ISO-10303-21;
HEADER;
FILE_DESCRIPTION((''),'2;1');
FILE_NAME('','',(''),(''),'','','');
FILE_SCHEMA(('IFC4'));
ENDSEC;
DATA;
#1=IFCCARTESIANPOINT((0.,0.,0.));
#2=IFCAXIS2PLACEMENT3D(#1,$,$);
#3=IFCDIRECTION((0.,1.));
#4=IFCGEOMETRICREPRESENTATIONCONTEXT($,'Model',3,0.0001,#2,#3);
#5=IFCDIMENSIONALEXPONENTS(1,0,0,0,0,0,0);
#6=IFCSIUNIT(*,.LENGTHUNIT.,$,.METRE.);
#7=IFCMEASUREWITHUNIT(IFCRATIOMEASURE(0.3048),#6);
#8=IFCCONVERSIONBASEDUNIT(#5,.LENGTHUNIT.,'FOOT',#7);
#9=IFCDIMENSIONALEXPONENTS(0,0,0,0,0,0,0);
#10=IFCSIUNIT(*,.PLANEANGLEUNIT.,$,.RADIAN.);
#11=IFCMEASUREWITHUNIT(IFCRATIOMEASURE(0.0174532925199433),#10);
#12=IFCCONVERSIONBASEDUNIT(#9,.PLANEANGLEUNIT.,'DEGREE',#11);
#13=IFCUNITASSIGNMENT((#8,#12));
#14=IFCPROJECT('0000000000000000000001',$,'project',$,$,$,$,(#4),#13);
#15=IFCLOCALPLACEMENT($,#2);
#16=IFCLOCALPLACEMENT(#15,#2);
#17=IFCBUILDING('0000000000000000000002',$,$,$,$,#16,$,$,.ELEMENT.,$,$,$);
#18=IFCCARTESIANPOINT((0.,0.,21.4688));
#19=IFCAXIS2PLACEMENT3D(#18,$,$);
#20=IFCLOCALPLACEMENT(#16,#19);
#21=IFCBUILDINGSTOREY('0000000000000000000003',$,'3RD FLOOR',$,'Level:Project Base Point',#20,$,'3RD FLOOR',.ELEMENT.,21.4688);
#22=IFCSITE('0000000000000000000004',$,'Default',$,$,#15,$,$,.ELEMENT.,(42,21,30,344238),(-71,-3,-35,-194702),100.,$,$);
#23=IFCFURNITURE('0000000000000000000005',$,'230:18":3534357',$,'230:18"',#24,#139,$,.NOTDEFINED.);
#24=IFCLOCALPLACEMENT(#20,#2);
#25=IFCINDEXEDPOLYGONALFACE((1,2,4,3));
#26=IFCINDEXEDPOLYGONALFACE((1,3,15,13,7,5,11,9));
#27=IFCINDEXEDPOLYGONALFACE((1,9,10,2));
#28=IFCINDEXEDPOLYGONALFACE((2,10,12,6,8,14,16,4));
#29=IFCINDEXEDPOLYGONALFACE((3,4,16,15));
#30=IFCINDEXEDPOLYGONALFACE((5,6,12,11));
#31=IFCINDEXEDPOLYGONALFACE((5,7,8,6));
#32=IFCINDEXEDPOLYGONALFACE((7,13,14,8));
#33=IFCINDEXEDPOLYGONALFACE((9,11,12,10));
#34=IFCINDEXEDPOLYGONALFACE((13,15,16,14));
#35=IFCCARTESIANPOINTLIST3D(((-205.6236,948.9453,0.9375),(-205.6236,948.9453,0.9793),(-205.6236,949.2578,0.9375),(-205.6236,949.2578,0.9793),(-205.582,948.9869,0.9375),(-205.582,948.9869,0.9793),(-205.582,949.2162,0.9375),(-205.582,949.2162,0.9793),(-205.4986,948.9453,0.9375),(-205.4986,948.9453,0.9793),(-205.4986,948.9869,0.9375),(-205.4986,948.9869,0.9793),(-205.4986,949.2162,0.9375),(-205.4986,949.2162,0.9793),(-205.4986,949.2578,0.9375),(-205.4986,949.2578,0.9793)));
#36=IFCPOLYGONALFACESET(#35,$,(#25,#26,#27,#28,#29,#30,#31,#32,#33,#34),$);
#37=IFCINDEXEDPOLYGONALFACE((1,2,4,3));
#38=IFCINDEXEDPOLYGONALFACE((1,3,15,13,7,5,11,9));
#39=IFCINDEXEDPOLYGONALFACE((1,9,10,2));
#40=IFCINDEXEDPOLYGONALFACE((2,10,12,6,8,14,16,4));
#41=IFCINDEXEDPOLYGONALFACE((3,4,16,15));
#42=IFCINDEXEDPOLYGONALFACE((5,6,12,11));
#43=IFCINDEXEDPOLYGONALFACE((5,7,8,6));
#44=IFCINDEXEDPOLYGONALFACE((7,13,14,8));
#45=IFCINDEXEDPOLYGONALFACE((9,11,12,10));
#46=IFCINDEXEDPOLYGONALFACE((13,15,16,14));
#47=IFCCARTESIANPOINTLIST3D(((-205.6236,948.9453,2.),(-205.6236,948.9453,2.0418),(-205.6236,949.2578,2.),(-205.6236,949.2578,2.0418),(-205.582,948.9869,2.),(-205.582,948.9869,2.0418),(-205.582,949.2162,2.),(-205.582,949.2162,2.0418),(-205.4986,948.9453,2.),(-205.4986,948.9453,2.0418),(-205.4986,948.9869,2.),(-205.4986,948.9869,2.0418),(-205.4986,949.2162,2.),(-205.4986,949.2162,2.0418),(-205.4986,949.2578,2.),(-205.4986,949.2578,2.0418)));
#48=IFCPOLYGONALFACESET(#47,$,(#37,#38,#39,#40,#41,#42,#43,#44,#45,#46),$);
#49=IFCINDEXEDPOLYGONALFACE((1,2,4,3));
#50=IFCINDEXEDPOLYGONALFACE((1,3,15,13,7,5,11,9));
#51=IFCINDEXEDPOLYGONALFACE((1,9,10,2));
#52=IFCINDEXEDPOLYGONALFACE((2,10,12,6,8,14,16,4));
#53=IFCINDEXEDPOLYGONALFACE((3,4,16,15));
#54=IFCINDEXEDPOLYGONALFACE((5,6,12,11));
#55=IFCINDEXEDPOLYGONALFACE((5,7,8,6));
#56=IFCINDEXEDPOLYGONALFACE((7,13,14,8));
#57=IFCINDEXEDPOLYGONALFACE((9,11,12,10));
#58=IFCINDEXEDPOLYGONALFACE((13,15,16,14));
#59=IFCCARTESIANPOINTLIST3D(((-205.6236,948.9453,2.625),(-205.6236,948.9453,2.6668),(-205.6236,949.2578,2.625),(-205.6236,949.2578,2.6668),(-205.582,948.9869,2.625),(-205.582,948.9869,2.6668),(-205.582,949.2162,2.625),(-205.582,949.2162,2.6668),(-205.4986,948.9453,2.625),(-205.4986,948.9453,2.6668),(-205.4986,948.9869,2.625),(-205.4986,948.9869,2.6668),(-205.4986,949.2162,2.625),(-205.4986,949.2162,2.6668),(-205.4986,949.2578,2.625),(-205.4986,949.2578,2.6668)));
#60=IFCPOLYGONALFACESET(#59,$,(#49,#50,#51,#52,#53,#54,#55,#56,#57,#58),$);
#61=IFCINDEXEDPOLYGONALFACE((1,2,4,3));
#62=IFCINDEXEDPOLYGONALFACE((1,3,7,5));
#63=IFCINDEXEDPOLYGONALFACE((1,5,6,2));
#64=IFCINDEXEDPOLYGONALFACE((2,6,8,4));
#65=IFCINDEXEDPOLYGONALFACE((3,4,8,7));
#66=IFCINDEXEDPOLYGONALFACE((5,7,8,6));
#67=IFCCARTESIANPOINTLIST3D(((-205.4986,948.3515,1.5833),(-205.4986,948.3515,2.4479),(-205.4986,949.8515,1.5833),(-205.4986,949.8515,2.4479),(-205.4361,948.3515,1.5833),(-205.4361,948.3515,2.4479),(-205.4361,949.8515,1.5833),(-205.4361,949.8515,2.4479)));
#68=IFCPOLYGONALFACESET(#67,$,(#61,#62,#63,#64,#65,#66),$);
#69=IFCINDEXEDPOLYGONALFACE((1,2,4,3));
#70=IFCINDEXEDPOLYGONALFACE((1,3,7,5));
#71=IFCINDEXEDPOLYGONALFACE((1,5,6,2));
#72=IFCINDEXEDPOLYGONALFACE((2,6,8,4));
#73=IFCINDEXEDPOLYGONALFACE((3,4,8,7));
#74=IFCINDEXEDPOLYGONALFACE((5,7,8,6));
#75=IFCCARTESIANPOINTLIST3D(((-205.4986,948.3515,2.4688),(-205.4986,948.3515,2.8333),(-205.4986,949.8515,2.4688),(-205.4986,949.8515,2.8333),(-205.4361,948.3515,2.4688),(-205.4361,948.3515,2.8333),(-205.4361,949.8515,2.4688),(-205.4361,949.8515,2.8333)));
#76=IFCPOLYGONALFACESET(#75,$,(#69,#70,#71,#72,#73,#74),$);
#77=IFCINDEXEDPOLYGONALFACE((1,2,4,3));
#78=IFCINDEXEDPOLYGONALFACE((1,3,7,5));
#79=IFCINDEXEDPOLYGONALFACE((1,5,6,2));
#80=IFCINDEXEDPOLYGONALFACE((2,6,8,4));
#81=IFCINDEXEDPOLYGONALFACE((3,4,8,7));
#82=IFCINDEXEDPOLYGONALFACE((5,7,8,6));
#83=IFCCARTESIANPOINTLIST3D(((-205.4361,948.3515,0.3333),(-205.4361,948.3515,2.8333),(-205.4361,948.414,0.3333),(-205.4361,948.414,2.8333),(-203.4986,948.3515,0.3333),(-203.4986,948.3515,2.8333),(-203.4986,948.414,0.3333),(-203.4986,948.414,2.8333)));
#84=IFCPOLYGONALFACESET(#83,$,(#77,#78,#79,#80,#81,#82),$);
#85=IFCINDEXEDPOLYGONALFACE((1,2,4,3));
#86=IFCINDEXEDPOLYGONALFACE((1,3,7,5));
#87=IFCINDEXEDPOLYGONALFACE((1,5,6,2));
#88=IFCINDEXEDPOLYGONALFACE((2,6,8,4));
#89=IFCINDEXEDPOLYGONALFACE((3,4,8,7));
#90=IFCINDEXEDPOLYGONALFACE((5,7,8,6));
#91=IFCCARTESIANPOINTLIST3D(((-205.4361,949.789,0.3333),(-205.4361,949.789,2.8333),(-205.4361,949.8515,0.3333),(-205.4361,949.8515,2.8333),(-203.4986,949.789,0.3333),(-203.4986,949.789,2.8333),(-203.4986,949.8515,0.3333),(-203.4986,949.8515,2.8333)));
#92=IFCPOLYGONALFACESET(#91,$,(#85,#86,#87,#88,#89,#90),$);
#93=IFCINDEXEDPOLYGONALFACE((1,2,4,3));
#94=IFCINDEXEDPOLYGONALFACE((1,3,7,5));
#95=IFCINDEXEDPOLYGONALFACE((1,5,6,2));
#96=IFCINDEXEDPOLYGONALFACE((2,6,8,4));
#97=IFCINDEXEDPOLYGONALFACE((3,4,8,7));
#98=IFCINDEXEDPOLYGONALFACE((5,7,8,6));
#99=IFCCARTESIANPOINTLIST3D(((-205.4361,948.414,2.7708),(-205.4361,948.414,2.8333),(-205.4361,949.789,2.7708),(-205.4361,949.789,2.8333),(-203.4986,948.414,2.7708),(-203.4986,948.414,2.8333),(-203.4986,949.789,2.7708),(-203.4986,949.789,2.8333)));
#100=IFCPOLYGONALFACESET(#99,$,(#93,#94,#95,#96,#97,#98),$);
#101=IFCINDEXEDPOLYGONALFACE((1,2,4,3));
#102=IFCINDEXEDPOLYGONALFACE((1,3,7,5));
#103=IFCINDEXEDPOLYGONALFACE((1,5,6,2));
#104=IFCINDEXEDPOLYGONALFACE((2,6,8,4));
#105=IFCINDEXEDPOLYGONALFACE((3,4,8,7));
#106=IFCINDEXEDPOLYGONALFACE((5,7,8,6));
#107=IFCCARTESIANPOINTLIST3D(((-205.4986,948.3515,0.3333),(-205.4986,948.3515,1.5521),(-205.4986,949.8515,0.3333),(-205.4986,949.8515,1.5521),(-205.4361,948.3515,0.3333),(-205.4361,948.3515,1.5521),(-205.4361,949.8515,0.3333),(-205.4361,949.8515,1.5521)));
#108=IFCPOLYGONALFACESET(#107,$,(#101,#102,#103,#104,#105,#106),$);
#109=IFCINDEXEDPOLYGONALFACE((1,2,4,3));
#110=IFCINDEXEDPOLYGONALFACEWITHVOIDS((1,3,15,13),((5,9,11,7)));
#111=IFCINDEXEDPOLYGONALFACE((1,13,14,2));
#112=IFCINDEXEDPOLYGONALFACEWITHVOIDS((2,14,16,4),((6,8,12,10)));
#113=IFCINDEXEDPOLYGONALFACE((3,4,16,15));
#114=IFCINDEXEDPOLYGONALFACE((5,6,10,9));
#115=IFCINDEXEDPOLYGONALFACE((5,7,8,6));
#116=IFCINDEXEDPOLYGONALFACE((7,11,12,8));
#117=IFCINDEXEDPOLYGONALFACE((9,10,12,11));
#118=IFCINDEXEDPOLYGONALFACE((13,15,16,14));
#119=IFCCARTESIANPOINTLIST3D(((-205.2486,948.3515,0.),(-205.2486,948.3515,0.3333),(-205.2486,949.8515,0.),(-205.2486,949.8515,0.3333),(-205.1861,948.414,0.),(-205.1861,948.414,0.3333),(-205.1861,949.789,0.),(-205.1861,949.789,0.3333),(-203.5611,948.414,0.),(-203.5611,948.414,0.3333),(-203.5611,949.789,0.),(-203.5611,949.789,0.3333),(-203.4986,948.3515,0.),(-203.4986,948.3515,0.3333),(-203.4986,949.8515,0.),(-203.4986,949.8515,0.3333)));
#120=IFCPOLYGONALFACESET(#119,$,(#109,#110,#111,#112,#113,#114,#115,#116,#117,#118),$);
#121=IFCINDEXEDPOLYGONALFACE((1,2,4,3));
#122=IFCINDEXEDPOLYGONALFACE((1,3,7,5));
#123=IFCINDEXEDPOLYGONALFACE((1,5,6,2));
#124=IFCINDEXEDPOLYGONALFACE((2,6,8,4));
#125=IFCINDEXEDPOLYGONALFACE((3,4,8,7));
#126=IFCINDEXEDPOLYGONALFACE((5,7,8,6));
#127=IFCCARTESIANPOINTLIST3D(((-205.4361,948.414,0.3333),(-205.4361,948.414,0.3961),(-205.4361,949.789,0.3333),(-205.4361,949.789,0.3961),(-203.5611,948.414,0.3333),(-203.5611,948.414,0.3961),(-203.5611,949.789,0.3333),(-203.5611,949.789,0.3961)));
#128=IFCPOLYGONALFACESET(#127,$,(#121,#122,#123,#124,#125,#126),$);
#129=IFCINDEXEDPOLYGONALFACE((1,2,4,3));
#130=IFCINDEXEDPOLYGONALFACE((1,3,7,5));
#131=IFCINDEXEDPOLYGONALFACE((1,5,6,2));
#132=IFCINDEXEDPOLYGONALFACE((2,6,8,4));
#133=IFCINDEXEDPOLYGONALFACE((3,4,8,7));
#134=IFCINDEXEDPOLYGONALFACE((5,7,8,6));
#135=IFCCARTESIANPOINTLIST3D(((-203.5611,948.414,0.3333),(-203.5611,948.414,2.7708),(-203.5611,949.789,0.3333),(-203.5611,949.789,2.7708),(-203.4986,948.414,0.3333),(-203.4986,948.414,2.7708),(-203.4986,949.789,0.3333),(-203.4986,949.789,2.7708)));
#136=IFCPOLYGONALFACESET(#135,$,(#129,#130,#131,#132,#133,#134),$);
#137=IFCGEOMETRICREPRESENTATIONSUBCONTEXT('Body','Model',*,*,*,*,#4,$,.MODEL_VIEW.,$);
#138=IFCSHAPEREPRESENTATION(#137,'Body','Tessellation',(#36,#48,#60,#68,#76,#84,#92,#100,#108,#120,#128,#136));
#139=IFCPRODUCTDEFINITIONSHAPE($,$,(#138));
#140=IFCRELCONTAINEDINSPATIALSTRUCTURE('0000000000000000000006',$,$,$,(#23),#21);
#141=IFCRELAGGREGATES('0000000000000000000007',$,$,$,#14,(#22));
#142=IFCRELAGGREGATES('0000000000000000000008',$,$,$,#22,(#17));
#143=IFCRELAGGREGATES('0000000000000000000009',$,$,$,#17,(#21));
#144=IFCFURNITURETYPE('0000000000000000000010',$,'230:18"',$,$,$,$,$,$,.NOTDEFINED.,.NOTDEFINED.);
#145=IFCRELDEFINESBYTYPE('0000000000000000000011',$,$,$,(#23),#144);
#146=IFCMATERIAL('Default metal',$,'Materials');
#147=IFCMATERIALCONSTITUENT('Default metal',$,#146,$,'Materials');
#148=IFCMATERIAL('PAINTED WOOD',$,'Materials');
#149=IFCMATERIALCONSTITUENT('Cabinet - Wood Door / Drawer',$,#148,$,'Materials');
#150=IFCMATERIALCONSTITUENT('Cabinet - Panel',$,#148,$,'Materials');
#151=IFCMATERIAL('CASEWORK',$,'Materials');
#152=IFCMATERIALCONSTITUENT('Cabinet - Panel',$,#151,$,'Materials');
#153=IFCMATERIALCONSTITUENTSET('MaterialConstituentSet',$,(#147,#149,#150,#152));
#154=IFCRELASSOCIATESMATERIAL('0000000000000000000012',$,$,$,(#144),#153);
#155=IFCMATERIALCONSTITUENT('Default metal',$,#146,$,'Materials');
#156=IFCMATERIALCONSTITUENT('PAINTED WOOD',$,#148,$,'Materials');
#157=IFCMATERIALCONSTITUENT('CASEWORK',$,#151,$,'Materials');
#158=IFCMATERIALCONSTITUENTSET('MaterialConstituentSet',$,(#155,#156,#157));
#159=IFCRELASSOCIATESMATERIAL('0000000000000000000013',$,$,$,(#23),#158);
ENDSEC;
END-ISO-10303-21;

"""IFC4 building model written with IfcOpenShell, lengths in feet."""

from ifc_helpers import new_model, entity, si_unit, converted_unit, direction, frame, frame_2d, origin, origin_2d_with_axis, place, context, subcontext, project, spatial, polyline, rectangle, outline, extrude, source, transform, mapped, material, constituent, constituent_set, type_object, type_shapes, element, save


model = new_model("IFC4")

# Units and contexts
model_context = context("Model", 3, precision=0.0001, world=origin(), true_north=direction((0.0, 1.0)))
body_context = subcontext(model_context, "Body", "Model", "MODEL_VIEW")
ifc_project = project(units=[converted_unit("LENGTHUNIT", "FOOT", entity("IfcRatioMeasure", 0.3048), si_unit("LENGTHUNIT", "METRE"), dimensions=[1, 0, 0, 0, 0, 0, 0]), converted_unit("PLANEANGLEUNIT", "DEGREE", entity("IfcRatioMeasure", 0.0174532925199433), si_unit("PLANEANGLEUNIT", "RADIAN"), dimensions=[0, 0, 0, 0, 0, 0, 0])], contexts=[model_context])

# Site, building, storey
site_placement = place(None, origin())
site = spatial("IfcSite", under=ifc_project, at=site_placement, Name="Default", CompositionType="ELEMENT", RefLatitude=(42, 21, 30, 344238), RefLongitude=(-71, -3, -35, -194702), RefElevation=100.0)
building_placement = place(site_placement, origin())
building = spatial("IfcBuilding", under=site, at=building_placement, CompositionType="ELEMENT")
storey_placement = place(building_placement, frame((0.0, 0.0, 21.4688)))
storey = spatial("IfcBuildingStorey", under=building, at=storey_placement, Name="3RD FLOOR", ObjectType="Level:Project Base Point", LongName="3RD FLOOR", CompositionType="ELEMENT", Elevation=21.4688)

# Furniture
ifc_material_1 = material(Name="CASEWORK", Category="Materials")
ifc_material_2 = material(Name="PAINTED WOOD", Category="Materials")
ifc_material_3 = material(Name="Default metal", Category="Materials")
ifc_constituent_1 = constituent(ifc_material_3, Name="Default metal", Category="Materials")
ifc_constituent_2 = constituent(ifc_material_2, Name="PAINTED WOOD", Category="Materials")
ifc_constituent_3 = constituent(ifc_material_1, Name="CASEWORK", Category="Materials")
ifc_constituent_set_1 = constituent_set(constituents=[ifc_constituent_1, ifc_constituent_2, ifc_constituent_3], Name="MaterialConstituentSet")
ifc_constituent_4 = constituent(ifc_material_3, Name="Default metal", Category="Materials")
ifc_constituent_5 = constituent(ifc_material_2, Name="Cabinet - Wood Door / Drawer", Category="Materials")
ifc_constituent_6 = constituent(ifc_material_2, Name="Cabinet - Panel", Category="Materials")
ifc_constituent_7 = constituent(ifc_material_1, Name="Cabinet - Panel", Category="Materials")
ifc_constituent_set_2 = constituent_set(constituents=[ifc_constituent_4, ifc_constituent_5, ifc_constituent_6, ifc_constituent_7], Name="MaterialConstituentSet")
furniture_type_1 = type_object("IfcFurnitureType", Name="230:18\"", AssemblyPlace="NOTDEFINED", PredefinedType="NOTDEFINED", material=ifc_constituent_set_2)
shared_shape_1 = source(origin(), body_context, "Body", "SweptSolid", [
    extrude(outline(polyline([(-0.1562, -0.0521), (-0.1146, -0.0521), (-0.1146, 0.0313), (0.1146, 0.0313), (0.1146, -0.0521), (0.1562, -0.0521), (0.1562, 0.0729), (-0.1562, 0.0729), (-0.1562, -0.0521)])), frame((0.0615, 2.0521, 0.9375)), (0.0, 0.0, 1.0), 0.0418),
    extrude(outline(polyline([(-0.1562, -0.0521), (-0.1146, -0.0521), (-0.1146, 0.0313), (0.1146, 0.0313), (0.1146, -0.0521), (0.1562, -0.0521), (0.1562, 0.0729), (-0.1562, 0.0729), (-0.1562, -0.0521)])), frame((0.0615, 2.0521, 2.0)), (0.0, 0.0, 1.0), 0.0418),
    extrude(outline(polyline([(-0.1562, -0.0521), (-0.1146, -0.0521), (-0.1146, 0.0313), (0.1146, 0.0313), (0.1146, -0.0521), (0.1562, -0.0521), (0.1562, 0.0729), (-0.1562, 0.0729), (-0.1562, -0.0521)])), frame((0.0615, 2.0521, 2.625)), (0.0, 0.0, 1.0), 0.0418),
    extrude(rectangle(XDim=1.5, YDim=0.0625, at=frame_2d((0.0, 0.0), x_axis=(1.0, 0.0))), frame((0.0615, 1.9688, 1.5833), z_axis=(0.0, 0.0, 1.0), x_axis=(-1.0, 0.0, 0.0)), (0.0, 0.0, 1.0), 0.8646),
    extrude(rectangle(XDim=1.5, YDim=0.0625, at=frame_2d((0.0, 0.0), x_axis=(1.0, 0.0))), frame((0.0615, 1.9688, 2.4688), z_axis=(0.0, 0.0, 1.0), x_axis=(-1.0, 0.0, 0.0)), (0.0, 0.0, 1.0), 0.3646),
    extrude(rectangle(XDim=1.9375, YDim=0.0625, at=frame_2d((0.0, 0.0), x_axis=(1.0, 0.0))), frame((-0.6573, 0.9687, 0.3333), z_axis=(0.0, 0.0, 1.0), x_axis=(0.0, -1.0, 0.0)), (0.0, 0.0, 1.0), 2.5),
    extrude(rectangle(XDim=1.9375, YDim=0.0625, at=frame_2d((0.0, 0.0), x_axis=(1.0, 0.0))), frame((0.7802, 0.9687, 0.3333), z_axis=(0.0, 0.0, 1.0), x_axis=(0.0, -1.0, 0.0)), (0.0, 0.0, 1.0), 2.5),
    extrude(rectangle(XDim=1.9375, YDim=1.375, at=origin_2d_with_axis()), frame((0.0615, 0.9687, 2.7708), z_axis=(0.0, 0.0, 1.0), x_axis=(0.0, 1.0, 0.0)), (0.0, 0.0, 1.0), 0.0625),
    extrude(rectangle(XDim=1.5, YDim=0.0625, at=frame_2d((0.0, 0.0), x_axis=(1.0, 0.0))), frame((0.0615, 1.9688, 0.3333), z_axis=(0.0, 0.0, 1.0), x_axis=(-1.0, 0.0, 0.0)), (0.0, 0.0, 1.0), 1.2187),
    extrude(outline(polyline([(-0.875, -0.75), (0.875, -0.75), (0.875, 0.75), (-0.875, 0.75), (-0.875, -0.75)]), holes=[polyline([(-0.8125, -0.6875), (-0.8125, 0.6875), (0.8125, 0.6875), (0.8125, -0.6875), (-0.8125, -0.6875)])]), frame((0.0615, 0.875, 0.0), z_axis=(0.0, 0.0, 1.0), x_axis=(0.0, -1.0, 0.0)), (0.0, 0.0, 1.0), 0.3333),
    extrude(rectangle(XDim=1.875, YDim=1.375, at=origin_2d_with_axis()), frame((0.0615, 1.0, 0.3333), z_axis=(0.0, 0.0, 1.0), x_axis=(0.0, 1.0, 0.0)), (0.0, 0.0, 1.0), 0.0627),
    extrude(rectangle(XDim=1.375, YDim=0.0625, at=origin_2d_with_axis()), frame((0.0615, 0.0312, 0.3333), z_axis=(0.0, 0.0, 1.0), x_axis=(-1.0, 0.0, 0.0)), (0.0, 0.0, 1.0), 2.4375),
])
type_shapes(furniture_type_1, [shared_shape_1])
furniture_1_placement = place(storey_placement, frame((-203.4986, 949.04, 0.0), z_axis=(0.0, 0.0, 1.0), x_axis=(0.0, 1.0, 0.0)))
element("IfcFurniture", 1, at=furniture_1_placement, inside=storey, type_object=furniture_type_1, material=ifc_constituent_set_1, Name="230:18\":3534357", ObjectType="230:18\"", PredefinedType="NOTDEFINED", context=body_context, shape_type="MappedRepresentation", body=[
    mapped(shared_shape_1, transform((0.0, 0.0, 0.0), scale=1.0)),
])

save(model, "model.ifc")
